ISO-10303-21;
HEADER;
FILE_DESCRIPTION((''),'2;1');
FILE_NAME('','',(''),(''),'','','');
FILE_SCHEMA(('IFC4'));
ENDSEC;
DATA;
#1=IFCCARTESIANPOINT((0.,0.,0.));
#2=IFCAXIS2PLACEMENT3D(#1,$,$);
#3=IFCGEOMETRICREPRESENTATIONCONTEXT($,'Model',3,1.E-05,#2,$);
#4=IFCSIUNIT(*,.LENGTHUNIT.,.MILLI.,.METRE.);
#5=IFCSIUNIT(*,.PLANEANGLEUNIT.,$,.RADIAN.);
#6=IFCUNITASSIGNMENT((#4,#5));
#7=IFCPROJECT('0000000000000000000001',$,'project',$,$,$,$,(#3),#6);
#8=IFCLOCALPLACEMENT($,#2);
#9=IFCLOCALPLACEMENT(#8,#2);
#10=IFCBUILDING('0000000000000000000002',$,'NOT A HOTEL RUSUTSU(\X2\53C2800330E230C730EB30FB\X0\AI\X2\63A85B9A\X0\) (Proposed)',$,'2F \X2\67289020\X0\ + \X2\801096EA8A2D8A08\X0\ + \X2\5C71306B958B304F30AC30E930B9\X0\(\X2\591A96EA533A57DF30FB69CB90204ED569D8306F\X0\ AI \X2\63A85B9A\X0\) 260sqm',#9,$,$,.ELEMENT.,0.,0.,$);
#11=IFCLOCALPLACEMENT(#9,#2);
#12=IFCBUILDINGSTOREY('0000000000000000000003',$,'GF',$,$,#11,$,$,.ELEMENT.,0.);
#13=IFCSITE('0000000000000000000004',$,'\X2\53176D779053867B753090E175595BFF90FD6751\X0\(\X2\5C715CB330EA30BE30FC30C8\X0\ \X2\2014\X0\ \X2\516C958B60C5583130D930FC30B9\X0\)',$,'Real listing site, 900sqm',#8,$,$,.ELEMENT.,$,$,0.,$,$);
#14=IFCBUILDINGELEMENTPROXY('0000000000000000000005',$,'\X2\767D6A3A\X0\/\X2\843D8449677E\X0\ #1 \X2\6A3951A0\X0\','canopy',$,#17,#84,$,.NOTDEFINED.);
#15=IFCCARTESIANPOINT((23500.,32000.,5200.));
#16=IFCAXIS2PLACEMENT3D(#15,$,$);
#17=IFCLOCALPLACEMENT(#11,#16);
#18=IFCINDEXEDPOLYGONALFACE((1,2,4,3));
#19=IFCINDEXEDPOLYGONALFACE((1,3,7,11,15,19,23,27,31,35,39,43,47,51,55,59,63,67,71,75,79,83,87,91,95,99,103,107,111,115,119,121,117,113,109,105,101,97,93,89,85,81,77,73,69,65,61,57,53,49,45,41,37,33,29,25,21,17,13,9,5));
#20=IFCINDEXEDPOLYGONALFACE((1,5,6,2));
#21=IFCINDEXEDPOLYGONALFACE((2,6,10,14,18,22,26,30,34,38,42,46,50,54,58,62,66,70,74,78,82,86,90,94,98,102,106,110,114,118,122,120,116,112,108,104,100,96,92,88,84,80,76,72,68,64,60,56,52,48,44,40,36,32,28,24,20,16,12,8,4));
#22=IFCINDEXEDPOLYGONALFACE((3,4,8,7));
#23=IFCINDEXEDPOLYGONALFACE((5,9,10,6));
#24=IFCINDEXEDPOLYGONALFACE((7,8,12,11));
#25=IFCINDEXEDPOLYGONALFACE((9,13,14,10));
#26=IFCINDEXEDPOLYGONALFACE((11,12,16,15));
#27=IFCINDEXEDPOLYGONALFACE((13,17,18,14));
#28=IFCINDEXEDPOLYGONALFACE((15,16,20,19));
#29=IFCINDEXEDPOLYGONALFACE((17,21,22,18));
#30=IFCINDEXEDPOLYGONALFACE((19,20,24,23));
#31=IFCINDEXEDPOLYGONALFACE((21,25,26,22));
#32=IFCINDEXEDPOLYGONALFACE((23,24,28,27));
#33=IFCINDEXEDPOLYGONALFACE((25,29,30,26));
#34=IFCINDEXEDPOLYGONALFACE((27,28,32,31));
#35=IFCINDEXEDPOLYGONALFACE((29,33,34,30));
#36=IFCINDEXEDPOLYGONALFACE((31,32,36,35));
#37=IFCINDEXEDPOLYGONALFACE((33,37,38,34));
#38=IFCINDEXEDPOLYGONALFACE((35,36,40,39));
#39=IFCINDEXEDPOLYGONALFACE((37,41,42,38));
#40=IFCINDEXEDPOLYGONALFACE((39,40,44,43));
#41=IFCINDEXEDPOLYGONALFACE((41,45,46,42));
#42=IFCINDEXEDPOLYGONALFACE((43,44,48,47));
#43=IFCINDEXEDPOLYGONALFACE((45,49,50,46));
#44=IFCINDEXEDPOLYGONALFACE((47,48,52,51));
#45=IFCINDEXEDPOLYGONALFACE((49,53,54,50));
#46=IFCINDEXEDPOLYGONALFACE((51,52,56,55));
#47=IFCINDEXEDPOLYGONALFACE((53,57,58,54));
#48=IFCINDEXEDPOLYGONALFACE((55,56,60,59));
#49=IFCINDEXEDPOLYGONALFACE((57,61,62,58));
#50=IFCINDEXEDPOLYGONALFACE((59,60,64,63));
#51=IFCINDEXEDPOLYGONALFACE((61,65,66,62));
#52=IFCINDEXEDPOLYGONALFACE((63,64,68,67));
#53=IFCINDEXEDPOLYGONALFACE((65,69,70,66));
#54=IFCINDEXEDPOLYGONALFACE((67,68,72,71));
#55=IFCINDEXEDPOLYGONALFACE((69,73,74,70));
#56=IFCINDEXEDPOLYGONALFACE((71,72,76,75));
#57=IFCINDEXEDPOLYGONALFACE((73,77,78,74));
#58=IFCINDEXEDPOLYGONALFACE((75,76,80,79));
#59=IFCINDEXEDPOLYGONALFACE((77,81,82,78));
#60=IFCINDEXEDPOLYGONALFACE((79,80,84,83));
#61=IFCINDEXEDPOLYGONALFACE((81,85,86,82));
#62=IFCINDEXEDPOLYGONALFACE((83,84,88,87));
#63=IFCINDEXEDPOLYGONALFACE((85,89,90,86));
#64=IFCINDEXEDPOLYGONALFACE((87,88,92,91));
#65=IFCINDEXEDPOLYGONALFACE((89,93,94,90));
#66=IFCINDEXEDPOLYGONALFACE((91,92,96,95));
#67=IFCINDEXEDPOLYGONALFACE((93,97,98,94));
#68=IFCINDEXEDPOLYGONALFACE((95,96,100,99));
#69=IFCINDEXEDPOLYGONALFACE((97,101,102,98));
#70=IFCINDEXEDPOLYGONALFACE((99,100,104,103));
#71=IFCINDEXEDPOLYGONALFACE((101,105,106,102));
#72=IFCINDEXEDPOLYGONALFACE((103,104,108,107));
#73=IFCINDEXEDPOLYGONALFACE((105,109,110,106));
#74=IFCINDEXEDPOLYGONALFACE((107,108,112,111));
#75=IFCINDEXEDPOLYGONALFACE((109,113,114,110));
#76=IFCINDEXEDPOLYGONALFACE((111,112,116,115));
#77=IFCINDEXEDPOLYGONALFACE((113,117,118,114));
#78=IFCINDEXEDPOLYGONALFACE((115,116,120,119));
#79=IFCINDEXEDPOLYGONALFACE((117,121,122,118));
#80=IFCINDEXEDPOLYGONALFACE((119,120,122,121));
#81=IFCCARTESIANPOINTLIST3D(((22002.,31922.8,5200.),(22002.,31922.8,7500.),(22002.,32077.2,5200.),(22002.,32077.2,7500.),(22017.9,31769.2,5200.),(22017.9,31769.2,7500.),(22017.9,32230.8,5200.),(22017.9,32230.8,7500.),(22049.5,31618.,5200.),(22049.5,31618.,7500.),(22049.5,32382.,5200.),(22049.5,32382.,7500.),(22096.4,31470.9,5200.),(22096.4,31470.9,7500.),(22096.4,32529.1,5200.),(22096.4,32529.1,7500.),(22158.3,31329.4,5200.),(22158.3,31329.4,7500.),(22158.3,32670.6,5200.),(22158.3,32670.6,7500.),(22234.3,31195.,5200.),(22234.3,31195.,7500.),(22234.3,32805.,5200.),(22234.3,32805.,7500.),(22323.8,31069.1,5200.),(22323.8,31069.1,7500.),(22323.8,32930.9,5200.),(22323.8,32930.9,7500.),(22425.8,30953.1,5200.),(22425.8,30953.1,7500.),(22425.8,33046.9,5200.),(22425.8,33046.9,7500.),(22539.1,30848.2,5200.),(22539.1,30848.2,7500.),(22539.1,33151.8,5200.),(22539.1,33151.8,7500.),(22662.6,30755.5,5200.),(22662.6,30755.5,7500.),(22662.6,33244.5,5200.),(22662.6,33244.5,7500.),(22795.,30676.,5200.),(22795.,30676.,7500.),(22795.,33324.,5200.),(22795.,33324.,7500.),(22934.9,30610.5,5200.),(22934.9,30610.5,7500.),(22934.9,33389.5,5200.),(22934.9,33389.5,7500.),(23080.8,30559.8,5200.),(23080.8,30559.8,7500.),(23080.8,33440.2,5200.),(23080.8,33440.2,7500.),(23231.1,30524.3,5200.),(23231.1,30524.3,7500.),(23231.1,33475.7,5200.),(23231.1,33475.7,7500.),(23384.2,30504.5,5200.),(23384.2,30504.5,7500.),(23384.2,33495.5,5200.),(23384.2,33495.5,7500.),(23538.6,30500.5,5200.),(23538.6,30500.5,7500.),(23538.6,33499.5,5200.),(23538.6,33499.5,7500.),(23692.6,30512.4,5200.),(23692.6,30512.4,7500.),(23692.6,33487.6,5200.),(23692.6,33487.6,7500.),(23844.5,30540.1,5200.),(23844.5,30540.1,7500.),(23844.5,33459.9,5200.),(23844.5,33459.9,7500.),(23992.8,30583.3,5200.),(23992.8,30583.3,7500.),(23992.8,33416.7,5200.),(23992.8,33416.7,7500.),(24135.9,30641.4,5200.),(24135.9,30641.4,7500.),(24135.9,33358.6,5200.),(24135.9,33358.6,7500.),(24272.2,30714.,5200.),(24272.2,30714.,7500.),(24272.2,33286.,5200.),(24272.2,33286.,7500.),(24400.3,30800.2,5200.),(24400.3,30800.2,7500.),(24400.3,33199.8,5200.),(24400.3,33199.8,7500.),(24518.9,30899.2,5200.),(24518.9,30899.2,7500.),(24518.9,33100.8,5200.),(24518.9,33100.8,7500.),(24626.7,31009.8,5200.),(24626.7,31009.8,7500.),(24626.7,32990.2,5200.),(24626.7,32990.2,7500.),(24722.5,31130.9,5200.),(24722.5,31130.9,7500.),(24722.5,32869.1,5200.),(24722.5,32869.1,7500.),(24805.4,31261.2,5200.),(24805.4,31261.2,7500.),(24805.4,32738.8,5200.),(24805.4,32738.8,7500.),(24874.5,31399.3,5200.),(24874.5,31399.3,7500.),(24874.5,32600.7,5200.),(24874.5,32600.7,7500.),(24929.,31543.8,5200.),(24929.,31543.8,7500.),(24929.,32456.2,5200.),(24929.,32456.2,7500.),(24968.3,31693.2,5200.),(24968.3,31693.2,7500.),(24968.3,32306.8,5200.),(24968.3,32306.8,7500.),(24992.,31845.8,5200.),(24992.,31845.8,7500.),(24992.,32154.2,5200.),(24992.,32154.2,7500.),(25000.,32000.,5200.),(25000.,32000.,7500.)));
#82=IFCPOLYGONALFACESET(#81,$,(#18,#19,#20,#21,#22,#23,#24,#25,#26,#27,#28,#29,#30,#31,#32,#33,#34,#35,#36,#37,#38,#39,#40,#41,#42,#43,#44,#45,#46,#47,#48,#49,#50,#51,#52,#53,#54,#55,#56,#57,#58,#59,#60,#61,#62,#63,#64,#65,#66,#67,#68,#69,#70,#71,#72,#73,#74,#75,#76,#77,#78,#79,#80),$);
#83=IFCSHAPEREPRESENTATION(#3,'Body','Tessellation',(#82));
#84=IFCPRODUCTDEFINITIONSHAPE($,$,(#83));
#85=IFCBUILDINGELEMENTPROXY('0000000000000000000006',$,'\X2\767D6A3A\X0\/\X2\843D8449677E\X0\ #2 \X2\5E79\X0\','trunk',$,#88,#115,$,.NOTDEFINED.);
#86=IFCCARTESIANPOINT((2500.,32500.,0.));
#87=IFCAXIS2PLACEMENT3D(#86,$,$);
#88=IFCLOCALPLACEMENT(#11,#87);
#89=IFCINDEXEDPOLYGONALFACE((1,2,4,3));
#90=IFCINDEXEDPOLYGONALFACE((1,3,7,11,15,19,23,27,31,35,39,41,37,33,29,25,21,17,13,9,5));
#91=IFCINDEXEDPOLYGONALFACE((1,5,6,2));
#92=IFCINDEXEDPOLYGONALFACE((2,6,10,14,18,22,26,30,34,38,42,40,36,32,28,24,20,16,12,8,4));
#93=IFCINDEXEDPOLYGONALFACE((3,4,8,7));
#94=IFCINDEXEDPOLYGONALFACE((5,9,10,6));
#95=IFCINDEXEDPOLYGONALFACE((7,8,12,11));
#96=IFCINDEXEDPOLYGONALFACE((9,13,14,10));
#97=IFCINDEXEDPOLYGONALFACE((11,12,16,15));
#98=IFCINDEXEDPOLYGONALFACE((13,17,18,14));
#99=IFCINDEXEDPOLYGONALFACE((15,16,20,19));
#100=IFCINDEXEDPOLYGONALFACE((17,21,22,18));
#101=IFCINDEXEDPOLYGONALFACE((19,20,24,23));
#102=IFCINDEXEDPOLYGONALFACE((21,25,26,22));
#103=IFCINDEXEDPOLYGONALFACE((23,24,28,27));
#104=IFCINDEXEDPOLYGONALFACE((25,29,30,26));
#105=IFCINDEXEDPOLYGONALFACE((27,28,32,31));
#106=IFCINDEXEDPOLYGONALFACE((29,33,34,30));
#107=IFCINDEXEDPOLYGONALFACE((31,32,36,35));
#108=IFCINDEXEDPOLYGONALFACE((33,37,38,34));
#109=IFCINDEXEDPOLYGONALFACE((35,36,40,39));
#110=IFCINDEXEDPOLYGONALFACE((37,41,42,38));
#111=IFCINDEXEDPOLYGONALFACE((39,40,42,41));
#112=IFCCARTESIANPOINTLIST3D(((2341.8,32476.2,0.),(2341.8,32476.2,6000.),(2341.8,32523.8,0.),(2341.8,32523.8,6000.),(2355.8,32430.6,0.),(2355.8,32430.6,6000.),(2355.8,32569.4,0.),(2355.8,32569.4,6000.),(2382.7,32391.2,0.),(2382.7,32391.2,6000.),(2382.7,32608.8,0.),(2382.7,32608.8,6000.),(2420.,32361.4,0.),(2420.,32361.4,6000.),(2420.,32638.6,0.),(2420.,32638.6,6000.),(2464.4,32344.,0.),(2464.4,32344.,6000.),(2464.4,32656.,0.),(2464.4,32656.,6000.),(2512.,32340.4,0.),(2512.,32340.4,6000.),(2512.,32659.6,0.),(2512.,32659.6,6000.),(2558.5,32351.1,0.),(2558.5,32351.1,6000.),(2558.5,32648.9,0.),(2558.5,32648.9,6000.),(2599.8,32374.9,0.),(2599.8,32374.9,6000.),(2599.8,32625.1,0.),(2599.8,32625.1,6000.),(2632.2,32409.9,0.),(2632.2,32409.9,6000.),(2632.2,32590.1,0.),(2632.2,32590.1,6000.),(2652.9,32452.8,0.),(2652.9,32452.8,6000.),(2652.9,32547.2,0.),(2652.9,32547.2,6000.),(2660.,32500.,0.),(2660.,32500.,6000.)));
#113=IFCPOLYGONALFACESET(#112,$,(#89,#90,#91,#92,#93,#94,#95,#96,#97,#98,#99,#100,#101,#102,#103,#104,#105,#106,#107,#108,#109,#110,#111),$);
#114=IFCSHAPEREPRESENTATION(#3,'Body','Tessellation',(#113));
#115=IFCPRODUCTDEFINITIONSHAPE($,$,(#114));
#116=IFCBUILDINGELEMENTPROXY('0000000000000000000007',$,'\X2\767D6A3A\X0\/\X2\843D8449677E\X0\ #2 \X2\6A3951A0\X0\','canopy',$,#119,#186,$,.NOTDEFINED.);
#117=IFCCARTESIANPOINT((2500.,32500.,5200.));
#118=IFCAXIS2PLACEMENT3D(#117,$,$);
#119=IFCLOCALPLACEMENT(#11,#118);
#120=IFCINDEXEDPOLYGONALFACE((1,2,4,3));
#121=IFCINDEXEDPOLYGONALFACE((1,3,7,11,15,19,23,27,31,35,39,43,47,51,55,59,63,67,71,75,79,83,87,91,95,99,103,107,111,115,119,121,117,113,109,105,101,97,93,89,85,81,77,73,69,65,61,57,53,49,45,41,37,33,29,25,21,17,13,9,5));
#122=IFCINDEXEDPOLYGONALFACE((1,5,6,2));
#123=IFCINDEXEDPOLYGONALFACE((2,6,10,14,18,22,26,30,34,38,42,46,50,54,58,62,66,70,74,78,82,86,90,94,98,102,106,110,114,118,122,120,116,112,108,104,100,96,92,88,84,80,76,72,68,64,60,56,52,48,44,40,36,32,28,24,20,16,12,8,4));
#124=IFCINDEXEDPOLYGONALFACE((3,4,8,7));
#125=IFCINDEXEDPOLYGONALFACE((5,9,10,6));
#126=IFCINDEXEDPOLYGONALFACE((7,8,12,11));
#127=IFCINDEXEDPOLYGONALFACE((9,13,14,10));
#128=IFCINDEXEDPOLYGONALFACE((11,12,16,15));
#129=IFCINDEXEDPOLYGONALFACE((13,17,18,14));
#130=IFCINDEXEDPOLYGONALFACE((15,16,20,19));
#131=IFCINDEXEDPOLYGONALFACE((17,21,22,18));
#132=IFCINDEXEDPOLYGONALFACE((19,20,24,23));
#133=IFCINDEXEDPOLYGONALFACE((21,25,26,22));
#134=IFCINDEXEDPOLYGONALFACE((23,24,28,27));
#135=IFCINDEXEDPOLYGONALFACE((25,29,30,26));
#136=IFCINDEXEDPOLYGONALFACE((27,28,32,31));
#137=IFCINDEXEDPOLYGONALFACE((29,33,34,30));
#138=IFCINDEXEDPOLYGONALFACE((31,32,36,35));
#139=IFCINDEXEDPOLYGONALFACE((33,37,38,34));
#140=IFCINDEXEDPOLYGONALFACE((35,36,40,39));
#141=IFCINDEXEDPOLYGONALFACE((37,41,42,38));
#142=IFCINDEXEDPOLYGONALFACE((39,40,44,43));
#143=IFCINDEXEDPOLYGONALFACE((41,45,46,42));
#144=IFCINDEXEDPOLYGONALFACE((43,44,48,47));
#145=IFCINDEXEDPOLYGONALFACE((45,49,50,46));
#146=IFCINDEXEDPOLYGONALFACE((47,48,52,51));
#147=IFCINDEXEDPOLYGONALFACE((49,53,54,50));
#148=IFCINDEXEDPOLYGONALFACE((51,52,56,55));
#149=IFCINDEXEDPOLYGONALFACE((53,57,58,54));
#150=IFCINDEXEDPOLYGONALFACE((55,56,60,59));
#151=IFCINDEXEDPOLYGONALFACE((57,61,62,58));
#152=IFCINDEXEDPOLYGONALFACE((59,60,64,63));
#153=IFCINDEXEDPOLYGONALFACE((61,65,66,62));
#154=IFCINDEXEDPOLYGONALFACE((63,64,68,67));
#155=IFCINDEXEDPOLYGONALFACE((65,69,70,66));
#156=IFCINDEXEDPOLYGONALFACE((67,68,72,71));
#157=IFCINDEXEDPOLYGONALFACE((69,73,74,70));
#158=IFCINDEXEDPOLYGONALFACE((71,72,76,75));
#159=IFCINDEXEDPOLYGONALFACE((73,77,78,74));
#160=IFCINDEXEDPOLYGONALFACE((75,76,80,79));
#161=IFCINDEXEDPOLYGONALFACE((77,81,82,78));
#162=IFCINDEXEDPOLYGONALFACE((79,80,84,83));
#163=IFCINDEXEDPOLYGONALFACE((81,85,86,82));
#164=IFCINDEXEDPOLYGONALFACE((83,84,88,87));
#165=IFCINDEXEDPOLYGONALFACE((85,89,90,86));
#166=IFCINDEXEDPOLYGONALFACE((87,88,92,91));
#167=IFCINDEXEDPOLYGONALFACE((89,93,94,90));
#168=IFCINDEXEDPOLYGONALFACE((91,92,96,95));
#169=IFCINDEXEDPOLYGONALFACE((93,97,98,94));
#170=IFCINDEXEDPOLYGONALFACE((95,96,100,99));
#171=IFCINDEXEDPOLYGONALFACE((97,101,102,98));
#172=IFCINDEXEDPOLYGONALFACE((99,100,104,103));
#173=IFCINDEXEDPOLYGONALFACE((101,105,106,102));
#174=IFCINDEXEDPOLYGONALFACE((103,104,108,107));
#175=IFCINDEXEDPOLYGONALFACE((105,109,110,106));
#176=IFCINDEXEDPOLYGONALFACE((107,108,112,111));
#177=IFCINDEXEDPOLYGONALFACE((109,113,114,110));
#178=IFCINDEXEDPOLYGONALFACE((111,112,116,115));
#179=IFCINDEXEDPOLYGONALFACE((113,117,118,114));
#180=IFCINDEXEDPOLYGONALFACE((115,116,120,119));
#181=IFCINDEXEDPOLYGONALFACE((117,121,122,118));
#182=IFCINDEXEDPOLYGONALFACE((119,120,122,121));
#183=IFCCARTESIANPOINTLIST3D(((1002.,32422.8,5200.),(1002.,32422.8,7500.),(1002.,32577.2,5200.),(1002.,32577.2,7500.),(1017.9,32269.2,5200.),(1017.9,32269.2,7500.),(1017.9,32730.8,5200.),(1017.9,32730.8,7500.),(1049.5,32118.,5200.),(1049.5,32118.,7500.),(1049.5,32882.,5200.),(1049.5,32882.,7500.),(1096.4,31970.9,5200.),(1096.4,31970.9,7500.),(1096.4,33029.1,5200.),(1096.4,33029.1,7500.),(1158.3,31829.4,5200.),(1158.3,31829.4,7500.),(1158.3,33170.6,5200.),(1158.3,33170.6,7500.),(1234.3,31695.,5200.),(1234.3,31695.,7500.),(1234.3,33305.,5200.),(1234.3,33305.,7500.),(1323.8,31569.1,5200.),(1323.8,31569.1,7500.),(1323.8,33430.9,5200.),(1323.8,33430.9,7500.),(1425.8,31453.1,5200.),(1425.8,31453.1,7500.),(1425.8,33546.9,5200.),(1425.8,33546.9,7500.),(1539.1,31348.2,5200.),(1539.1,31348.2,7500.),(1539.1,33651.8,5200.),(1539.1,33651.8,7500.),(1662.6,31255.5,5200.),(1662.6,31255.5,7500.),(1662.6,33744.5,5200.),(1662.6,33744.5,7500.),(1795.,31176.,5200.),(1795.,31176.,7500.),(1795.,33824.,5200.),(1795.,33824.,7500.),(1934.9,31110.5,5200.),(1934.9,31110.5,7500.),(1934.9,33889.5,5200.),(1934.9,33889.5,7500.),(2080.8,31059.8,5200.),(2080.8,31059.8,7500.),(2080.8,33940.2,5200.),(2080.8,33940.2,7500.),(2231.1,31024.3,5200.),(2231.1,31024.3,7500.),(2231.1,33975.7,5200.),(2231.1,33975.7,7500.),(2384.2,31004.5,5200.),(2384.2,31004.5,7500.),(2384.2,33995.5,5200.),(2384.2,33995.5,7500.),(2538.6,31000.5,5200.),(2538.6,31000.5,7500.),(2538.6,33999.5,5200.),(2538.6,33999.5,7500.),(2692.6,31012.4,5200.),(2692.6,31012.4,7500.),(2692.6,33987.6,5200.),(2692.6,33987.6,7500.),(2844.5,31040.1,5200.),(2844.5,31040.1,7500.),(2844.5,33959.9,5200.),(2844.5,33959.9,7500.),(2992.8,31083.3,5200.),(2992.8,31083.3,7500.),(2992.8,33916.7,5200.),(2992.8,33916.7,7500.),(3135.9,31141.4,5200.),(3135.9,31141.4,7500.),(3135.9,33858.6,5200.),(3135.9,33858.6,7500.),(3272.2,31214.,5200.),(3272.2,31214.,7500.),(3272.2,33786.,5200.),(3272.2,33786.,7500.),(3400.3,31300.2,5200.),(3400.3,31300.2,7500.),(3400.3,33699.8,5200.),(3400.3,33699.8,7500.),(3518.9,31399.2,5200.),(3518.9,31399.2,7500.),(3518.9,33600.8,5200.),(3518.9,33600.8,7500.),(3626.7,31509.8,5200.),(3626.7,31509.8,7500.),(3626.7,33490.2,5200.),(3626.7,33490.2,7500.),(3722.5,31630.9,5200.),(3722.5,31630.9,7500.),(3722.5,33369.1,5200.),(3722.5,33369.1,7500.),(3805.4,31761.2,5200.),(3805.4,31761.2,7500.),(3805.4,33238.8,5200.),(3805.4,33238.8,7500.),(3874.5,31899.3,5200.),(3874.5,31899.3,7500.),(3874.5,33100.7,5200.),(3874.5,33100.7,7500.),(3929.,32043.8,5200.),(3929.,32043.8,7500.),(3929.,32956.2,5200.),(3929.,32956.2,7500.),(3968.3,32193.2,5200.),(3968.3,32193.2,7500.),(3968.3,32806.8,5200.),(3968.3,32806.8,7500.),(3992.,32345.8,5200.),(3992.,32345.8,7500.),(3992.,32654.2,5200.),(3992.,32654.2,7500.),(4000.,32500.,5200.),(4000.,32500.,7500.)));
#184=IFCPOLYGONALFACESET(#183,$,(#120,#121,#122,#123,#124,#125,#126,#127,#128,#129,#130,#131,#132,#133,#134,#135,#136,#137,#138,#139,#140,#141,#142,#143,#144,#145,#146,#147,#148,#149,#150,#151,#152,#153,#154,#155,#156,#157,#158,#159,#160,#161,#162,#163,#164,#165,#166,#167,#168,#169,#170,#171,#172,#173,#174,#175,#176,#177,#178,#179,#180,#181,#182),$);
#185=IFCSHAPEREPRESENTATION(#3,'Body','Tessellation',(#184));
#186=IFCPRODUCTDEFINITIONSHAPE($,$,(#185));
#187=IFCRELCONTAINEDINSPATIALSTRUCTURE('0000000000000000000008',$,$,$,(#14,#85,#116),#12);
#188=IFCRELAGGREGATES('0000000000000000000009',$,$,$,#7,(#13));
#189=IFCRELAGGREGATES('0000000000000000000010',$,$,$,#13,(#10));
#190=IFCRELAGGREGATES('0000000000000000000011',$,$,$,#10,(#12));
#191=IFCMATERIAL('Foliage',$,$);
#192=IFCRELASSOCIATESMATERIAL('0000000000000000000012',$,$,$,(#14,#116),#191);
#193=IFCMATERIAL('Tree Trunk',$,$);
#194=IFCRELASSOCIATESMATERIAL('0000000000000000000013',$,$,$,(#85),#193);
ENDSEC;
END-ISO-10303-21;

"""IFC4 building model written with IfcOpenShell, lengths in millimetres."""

from ifc_helpers import new_model, si_unit, frame, origin, origin_2d, place, context, project, spatial, circle, extrude, material, element, save


model = new_model("IFC4")

# Units and contexts
model_context = context("Model", 3, precision=1e-05, world=origin())
ifc_project = project(units=[si_unit("LENGTHUNIT", "METRE", prefix="MILLI"), si_unit("PLANEANGLEUNIT", "RADIAN")], contexts=[model_context])

# Site, building, storey
site_placement = place(None, origin())
site = spatial("IfcSite", under=ifc_project, at=site_placement, Name="北海道虻田郡留寿都村(山岳リゾート — 公開情報ベース)", ObjectType="Real listing site, 900sqm", CompositionType="ELEMENT", RefElevation=0.0)
building_placement = place(site_placement, origin())
building = spatial("IfcBuilding", under=site, at=building_placement, Name="NOT A HOTEL RUSUTSU(参考モデル・AI推定) (Proposed)", ObjectType="2F 木造 + 耐雪設計 + 山に開くガラス(多雪区域・構造仕様は AI 推定) 260sqm", CompositionType="ELEMENT", ElevationOfRefHeight=0.0, ElevationOfTerrain=0.0)
storey_placement = place(building_placement, origin())
storey = spatial("IfcBuildingStorey", under=building, at=storey_placement, Name="GF", CompositionType="ELEMENT", Elevation=0.0)

# Building element proxies
ifc_material_1 = material(Name="Tree Trunk")
ifc_material_2 = material(Name="Foliage")
proxy_1_placement = place(storey_placement, frame((23500.0, 32000.0, 5200.0)))
element("IfcBuildingElementProxy", 1, at=proxy_1_placement, inside=storey, material=ifc_material_2, Name="白樺/落葉松 #1 樹冠", Description="canopy", PredefinedType="NOTDEFINED", context=model_context, shape_type="SweptSolid", body=[
    extrude(circle(Radius=1500.0, at=origin_2d()), frame((23500.0, 32000.0, 5200.0)), (0.0, 0.0, 1.0), 2300.0),
])
proxy_2_placement = place(storey_placement, frame((2500.0, 32500.0, 0.0)))
element("IfcBuildingElementProxy", 2, at=proxy_2_placement, inside=storey, material=ifc_material_1, Name="白樺/落葉松 #2 幹", Description="trunk", PredefinedType="NOTDEFINED", context=model_context, shape_type="SweptSolid", body=[
    extrude(circle(Radius=160.0, at=origin_2d()), frame((2500.0, 32500.0, 0.0)), (0.0, 0.0, 1.0), 6000.0),
])
proxy_3_placement = place(storey_placement, frame((2500.0, 32500.0, 5200.0)))
element("IfcBuildingElementProxy", 3, at=proxy_3_placement, inside=storey, material=ifc_material_2, Name="白樺/落葉松 #2 樹冠", Description="canopy", PredefinedType="NOTDEFINED", context=model_context, shape_type="SweptSolid", body=[
    extrude(circle(Radius=1500.0, at=origin_2d()), frame((2500.0, 32500.0, 5200.0)), (0.0, 0.0, 1.0), 2300.0),
])

save(model, "model.ifc")
